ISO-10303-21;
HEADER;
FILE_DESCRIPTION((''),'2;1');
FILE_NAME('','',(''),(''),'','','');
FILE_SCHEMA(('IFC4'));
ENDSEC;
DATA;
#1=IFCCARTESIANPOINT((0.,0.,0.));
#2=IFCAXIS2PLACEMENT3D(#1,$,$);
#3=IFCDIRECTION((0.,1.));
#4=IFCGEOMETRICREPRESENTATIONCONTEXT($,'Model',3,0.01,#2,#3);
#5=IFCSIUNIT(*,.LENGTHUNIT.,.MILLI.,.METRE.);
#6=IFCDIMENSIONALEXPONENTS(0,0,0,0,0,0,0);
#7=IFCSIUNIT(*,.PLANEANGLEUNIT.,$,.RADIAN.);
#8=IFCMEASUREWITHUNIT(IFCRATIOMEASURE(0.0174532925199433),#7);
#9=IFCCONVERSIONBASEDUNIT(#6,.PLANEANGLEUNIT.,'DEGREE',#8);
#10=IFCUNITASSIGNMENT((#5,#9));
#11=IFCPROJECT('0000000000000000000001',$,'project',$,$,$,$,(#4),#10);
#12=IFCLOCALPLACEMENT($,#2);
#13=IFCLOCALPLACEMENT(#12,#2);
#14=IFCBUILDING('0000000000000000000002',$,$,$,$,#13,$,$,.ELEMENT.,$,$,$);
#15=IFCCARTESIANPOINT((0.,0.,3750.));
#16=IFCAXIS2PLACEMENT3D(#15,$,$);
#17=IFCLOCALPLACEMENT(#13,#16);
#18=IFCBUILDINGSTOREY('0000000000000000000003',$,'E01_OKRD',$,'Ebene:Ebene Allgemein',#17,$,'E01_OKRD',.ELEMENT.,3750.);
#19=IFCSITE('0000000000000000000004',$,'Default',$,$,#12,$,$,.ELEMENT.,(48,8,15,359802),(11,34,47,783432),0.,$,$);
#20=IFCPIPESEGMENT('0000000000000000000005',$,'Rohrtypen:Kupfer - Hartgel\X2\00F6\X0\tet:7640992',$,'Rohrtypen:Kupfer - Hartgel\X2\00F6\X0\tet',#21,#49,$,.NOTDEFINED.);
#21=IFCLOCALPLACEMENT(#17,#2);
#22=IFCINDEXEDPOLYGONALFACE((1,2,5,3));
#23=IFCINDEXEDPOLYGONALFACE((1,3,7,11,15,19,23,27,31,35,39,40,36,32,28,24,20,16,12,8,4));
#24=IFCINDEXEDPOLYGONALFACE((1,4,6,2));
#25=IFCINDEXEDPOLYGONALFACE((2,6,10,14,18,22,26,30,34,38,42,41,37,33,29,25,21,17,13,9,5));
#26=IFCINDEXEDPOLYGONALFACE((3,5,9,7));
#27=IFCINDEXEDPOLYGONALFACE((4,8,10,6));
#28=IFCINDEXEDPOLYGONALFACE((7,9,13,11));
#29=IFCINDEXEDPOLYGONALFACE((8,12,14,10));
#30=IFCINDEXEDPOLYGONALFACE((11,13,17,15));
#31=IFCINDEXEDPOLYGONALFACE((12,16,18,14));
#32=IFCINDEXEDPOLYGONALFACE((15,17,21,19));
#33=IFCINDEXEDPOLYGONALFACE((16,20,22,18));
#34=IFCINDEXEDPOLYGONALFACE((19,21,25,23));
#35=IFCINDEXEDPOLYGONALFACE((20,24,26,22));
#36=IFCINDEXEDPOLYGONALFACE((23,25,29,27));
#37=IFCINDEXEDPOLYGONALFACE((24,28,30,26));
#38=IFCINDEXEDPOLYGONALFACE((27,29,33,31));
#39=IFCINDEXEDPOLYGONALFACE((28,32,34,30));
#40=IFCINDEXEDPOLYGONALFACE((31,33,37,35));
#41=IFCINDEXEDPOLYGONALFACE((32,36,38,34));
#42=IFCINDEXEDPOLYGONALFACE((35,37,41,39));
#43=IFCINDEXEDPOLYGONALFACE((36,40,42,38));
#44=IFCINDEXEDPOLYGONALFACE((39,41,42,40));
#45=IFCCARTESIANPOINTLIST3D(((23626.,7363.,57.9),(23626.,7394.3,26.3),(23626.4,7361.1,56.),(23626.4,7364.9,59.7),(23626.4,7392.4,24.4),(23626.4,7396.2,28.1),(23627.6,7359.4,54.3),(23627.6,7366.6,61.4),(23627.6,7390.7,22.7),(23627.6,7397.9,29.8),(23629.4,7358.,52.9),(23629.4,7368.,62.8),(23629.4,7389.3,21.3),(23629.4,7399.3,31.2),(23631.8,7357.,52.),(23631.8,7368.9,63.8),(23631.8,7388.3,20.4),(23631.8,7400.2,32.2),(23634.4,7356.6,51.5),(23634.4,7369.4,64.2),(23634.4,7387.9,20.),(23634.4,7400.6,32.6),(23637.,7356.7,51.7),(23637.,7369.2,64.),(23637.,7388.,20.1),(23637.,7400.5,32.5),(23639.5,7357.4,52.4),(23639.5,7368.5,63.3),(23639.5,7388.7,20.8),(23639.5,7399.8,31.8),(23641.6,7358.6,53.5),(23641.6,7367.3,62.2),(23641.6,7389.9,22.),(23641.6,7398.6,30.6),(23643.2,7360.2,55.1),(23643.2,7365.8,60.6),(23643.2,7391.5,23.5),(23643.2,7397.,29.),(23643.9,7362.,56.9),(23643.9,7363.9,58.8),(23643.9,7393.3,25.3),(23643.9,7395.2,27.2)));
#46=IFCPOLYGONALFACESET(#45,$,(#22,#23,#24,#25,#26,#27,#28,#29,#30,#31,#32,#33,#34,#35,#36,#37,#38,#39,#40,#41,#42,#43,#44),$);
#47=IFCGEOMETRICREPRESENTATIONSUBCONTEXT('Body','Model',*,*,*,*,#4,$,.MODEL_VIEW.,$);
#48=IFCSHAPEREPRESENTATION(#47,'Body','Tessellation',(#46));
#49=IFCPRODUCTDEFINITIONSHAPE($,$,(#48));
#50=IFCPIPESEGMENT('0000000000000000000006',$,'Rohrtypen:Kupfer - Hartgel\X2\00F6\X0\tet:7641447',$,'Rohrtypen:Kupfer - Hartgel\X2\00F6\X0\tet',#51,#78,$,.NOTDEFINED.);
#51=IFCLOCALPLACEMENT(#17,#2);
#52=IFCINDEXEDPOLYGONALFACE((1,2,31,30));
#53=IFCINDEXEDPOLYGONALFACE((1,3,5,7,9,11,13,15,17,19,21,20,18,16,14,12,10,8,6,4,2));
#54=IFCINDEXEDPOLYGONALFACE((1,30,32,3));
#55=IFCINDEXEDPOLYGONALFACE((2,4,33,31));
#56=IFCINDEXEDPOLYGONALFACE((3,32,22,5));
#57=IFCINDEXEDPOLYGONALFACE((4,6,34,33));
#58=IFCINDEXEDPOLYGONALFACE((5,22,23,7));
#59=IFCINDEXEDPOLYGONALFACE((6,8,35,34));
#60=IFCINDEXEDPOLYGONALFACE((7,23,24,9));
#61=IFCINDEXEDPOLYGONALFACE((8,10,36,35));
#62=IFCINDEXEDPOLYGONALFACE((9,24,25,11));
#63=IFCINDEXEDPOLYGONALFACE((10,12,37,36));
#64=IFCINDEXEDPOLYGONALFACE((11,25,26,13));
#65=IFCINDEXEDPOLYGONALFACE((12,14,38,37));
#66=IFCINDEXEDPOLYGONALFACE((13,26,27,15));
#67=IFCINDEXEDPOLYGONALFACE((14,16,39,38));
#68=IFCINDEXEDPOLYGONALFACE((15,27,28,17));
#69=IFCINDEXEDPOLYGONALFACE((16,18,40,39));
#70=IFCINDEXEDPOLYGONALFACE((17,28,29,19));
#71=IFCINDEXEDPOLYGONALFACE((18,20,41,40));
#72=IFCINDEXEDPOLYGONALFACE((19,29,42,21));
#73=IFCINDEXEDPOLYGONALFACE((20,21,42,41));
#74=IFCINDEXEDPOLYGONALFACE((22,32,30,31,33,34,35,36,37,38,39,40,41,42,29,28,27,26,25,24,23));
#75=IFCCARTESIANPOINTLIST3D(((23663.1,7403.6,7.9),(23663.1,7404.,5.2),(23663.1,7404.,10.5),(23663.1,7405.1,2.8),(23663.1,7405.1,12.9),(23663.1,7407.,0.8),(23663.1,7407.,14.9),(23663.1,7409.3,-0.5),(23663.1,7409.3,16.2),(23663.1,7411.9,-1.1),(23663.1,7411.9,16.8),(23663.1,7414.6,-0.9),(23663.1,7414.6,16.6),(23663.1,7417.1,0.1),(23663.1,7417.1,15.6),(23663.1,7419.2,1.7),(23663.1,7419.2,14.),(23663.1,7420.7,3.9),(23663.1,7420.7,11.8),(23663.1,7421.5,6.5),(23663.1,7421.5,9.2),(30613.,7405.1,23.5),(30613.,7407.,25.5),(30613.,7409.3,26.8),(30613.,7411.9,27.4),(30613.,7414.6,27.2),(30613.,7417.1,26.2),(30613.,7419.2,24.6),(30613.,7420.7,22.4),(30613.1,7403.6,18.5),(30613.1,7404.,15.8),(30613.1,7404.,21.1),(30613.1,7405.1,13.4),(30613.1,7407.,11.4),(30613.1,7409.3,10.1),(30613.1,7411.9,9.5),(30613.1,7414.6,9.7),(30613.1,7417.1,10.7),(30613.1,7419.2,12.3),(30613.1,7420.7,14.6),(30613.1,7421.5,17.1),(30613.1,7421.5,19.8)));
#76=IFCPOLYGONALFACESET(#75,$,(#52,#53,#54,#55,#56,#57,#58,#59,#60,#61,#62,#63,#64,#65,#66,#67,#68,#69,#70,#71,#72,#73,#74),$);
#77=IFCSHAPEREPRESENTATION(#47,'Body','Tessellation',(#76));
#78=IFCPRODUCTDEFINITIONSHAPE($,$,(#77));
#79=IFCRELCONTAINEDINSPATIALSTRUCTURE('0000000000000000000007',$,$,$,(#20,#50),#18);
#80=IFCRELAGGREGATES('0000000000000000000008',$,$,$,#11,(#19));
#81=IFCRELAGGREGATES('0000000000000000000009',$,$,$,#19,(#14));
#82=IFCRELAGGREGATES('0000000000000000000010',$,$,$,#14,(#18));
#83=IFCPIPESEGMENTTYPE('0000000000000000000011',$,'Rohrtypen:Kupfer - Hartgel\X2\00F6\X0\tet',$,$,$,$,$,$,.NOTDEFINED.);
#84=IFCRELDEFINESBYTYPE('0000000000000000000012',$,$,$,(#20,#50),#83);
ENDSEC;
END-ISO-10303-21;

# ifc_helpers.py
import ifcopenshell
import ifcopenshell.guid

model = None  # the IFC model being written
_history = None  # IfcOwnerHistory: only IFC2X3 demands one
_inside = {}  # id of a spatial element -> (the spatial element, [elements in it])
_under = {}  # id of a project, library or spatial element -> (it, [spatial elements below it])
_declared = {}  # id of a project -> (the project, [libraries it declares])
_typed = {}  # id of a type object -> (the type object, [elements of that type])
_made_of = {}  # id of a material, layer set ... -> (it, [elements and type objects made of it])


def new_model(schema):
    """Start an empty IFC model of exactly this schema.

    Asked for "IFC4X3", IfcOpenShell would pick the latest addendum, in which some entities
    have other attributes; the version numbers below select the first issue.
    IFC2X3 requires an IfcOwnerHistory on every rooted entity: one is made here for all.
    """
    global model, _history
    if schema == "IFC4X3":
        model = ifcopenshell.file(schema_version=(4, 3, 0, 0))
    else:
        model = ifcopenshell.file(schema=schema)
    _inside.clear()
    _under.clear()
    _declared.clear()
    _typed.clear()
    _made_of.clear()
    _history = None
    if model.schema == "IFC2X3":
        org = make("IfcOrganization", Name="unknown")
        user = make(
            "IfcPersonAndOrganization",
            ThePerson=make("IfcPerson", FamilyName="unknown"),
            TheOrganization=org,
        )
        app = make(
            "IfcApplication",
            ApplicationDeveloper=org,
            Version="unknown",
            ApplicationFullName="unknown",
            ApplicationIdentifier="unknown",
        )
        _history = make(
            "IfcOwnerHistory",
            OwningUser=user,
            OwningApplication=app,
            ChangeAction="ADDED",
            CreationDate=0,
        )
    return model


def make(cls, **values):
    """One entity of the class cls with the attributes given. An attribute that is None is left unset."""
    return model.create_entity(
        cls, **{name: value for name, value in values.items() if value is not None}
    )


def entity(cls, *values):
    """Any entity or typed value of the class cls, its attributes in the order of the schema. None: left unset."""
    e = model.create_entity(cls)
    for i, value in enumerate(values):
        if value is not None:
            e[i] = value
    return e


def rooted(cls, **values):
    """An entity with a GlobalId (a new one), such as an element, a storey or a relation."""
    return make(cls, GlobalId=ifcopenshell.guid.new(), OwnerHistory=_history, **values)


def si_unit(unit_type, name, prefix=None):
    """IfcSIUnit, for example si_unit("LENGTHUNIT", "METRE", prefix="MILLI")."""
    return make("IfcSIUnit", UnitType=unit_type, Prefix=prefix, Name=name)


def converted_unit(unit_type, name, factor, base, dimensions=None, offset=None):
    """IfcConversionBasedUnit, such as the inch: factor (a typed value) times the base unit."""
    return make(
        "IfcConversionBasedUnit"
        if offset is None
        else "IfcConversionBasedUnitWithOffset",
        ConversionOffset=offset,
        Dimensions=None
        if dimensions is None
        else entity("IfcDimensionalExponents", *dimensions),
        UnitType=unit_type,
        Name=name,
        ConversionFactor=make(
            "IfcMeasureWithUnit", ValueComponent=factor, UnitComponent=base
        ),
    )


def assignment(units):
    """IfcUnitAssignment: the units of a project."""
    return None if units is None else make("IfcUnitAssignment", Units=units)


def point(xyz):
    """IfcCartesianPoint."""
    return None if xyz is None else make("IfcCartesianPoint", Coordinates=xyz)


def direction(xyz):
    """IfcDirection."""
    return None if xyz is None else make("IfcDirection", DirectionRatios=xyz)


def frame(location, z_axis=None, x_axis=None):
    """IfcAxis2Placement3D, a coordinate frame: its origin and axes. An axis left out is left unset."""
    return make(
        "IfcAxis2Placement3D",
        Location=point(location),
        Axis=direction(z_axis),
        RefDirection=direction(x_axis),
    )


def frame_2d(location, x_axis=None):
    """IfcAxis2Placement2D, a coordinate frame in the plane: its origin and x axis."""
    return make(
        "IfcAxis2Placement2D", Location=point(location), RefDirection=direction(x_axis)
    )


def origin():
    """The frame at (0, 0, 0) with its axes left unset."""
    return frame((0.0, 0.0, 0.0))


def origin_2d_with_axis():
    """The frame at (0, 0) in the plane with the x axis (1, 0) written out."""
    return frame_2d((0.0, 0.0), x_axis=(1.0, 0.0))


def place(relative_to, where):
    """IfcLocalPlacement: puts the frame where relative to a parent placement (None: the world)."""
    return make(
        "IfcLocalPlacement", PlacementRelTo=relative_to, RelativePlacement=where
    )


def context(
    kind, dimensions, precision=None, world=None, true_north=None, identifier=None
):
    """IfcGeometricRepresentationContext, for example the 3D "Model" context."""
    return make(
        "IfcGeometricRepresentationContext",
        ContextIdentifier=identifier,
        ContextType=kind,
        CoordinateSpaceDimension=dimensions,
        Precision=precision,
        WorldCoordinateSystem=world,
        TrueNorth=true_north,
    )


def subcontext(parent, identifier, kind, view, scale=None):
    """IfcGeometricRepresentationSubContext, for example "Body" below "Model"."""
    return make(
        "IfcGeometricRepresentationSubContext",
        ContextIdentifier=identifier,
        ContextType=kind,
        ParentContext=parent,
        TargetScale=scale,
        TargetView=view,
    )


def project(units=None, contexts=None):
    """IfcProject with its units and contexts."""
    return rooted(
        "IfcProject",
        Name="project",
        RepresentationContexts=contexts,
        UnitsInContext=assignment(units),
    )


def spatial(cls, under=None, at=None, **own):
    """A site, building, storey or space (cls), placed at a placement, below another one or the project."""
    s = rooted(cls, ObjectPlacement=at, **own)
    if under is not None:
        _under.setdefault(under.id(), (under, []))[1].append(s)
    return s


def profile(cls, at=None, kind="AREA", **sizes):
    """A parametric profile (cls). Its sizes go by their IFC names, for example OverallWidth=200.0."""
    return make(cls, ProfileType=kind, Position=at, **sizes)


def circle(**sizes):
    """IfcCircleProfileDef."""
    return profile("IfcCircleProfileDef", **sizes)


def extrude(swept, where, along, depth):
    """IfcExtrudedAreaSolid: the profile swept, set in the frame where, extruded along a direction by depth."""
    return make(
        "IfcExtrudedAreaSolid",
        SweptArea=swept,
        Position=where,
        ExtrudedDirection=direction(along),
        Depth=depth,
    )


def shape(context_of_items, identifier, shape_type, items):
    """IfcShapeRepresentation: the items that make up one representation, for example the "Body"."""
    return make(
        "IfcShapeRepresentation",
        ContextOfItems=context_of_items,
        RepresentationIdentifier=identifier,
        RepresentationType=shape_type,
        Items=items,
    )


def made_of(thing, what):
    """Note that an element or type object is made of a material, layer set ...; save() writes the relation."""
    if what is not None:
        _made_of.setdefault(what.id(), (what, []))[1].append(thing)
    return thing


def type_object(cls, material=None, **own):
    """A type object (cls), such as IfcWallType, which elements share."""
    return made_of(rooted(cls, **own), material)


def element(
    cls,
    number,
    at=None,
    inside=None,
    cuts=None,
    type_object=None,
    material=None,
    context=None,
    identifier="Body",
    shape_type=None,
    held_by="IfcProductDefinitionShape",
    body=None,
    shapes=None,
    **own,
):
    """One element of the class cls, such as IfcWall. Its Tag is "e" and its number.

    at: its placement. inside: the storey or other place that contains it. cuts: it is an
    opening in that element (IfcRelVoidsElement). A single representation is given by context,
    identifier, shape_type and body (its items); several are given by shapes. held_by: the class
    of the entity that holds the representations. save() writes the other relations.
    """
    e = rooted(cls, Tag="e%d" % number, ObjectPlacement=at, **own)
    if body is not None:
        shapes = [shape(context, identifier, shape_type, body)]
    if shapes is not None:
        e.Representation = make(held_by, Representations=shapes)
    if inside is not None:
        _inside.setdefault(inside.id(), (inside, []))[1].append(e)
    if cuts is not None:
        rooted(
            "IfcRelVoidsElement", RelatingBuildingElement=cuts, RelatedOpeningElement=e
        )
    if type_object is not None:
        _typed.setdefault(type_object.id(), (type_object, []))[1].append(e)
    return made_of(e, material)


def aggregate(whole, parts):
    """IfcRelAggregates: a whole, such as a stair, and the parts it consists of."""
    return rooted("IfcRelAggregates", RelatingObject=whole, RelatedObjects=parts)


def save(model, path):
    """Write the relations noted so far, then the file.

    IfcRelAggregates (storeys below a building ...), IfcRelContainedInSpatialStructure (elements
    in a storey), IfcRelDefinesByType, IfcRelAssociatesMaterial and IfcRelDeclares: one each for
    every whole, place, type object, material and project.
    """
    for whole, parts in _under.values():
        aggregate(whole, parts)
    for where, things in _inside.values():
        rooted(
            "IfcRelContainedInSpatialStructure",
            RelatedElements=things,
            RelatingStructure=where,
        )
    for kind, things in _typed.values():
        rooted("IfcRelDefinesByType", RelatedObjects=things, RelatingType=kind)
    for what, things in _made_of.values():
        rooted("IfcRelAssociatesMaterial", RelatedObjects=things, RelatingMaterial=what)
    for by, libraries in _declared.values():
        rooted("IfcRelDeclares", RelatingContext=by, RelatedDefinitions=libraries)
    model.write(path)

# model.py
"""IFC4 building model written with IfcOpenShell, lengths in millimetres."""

from ifc_helpers import new_model, entity, si_unit, converted_unit, direction, frame, origin, origin_2d_with_axis, place, context, subcontext, project, spatial, circle, extrude, type_object, element, save


model = new_model("IFC4")

# Units and contexts
model_context = context("Model", 3, precision=0.01, world=origin(), true_north=direction((0.0, 1.0)))
body_context = subcontext(model_context, "Body", "Model", "MODEL_VIEW")
ifc_project = project(units=[si_unit("LENGTHUNIT", "METRE", prefix="MILLI"), converted_unit("PLANEANGLEUNIT", "DEGREE", entity("IfcRatioMeasure", 0.0174532925199433), si_unit("PLANEANGLEUNIT", "RADIAN"), dimensions=[0, 0, 0, 0, 0, 0, 0])], contexts=[model_context])

# Site, building, storey
site_placement = place(None, origin())
site = spatial("IfcSite", under=ifc_project, at=site_placement, Name="Default", CompositionType="ELEMENT", RefLatitude=(48, 8, 15, 359802), RefLongitude=(11, 34, 47, 783432), RefElevation=0.0)
building_placement = place(site_placement, origin())
building = spatial("IfcBuilding", under=site, at=building_placement, CompositionType="ELEMENT")
storey_placement = place(building_placement, frame((0.0, 0.0, 3750.0)))
storey = spatial("IfcBuildingStorey", under=building, at=storey_placement, Name="E01_OKRD", ObjectType="Ebene:Ebene Allgemein", LongName="E01_OKRD", CompositionType="ELEMENT", Elevation=3750.0)

# Pipe segments
pipe_segment_type = type_object("IfcPipeSegmentType", Name="Rohrtypen:Kupfer - Hartgelötet", PredefinedType="NOTDEFINED")
pipe_segment_1_placement = place(storey_placement, frame((23624.4, 7355.0, 18.3)))
element("IfcPipeSegment", 1, at=pipe_segment_1_placement, inside=storey, type_object=pipe_segment_type, Name="Rohrtypen:Kupfer - Hartgelötet:7640992", ObjectType="Rohrtypen:Kupfer - Hartgelötet", PredefinedType="NOTDEFINED", context=body_context, shape_type="SweptSolid", body=[
    extrude(circle(Radius=9.0, at=origin_2d_with_axis()), frame((10.6, 39.3, 7.9), z_axis=(0.0, -0.70394, 0.71026), x_axis=(-1.0, 0.0, 0.0)), (0.0, 0.0, 1.0), 44.5),
])
pipe_segment_2_placement = place(storey_placement, frame((23663.1, 7402.0, -2.7)))
element("IfcPipeSegment", 2, at=pipe_segment_2_placement, inside=storey, type_object=pipe_segment_type, Name="Rohrtypen:Kupfer - Hartgelötet:7641447", ObjectType="Rohrtypen:Kupfer - Hartgelötet", PredefinedType="NOTDEFINED", context=body_context, shape_type="SweptSolid", body=[
    extrude(circle(Radius=9.0, at=origin_2d_with_axis()), frame((0.0, 10.6, 10.6), z_axis=(0.999999, 0.0, 0.001525), x_axis=(0.0, -1.0, 0.0)), (0.0, 0.0, 1.0), 6950.0),
])

save(model, "model.ifc")
